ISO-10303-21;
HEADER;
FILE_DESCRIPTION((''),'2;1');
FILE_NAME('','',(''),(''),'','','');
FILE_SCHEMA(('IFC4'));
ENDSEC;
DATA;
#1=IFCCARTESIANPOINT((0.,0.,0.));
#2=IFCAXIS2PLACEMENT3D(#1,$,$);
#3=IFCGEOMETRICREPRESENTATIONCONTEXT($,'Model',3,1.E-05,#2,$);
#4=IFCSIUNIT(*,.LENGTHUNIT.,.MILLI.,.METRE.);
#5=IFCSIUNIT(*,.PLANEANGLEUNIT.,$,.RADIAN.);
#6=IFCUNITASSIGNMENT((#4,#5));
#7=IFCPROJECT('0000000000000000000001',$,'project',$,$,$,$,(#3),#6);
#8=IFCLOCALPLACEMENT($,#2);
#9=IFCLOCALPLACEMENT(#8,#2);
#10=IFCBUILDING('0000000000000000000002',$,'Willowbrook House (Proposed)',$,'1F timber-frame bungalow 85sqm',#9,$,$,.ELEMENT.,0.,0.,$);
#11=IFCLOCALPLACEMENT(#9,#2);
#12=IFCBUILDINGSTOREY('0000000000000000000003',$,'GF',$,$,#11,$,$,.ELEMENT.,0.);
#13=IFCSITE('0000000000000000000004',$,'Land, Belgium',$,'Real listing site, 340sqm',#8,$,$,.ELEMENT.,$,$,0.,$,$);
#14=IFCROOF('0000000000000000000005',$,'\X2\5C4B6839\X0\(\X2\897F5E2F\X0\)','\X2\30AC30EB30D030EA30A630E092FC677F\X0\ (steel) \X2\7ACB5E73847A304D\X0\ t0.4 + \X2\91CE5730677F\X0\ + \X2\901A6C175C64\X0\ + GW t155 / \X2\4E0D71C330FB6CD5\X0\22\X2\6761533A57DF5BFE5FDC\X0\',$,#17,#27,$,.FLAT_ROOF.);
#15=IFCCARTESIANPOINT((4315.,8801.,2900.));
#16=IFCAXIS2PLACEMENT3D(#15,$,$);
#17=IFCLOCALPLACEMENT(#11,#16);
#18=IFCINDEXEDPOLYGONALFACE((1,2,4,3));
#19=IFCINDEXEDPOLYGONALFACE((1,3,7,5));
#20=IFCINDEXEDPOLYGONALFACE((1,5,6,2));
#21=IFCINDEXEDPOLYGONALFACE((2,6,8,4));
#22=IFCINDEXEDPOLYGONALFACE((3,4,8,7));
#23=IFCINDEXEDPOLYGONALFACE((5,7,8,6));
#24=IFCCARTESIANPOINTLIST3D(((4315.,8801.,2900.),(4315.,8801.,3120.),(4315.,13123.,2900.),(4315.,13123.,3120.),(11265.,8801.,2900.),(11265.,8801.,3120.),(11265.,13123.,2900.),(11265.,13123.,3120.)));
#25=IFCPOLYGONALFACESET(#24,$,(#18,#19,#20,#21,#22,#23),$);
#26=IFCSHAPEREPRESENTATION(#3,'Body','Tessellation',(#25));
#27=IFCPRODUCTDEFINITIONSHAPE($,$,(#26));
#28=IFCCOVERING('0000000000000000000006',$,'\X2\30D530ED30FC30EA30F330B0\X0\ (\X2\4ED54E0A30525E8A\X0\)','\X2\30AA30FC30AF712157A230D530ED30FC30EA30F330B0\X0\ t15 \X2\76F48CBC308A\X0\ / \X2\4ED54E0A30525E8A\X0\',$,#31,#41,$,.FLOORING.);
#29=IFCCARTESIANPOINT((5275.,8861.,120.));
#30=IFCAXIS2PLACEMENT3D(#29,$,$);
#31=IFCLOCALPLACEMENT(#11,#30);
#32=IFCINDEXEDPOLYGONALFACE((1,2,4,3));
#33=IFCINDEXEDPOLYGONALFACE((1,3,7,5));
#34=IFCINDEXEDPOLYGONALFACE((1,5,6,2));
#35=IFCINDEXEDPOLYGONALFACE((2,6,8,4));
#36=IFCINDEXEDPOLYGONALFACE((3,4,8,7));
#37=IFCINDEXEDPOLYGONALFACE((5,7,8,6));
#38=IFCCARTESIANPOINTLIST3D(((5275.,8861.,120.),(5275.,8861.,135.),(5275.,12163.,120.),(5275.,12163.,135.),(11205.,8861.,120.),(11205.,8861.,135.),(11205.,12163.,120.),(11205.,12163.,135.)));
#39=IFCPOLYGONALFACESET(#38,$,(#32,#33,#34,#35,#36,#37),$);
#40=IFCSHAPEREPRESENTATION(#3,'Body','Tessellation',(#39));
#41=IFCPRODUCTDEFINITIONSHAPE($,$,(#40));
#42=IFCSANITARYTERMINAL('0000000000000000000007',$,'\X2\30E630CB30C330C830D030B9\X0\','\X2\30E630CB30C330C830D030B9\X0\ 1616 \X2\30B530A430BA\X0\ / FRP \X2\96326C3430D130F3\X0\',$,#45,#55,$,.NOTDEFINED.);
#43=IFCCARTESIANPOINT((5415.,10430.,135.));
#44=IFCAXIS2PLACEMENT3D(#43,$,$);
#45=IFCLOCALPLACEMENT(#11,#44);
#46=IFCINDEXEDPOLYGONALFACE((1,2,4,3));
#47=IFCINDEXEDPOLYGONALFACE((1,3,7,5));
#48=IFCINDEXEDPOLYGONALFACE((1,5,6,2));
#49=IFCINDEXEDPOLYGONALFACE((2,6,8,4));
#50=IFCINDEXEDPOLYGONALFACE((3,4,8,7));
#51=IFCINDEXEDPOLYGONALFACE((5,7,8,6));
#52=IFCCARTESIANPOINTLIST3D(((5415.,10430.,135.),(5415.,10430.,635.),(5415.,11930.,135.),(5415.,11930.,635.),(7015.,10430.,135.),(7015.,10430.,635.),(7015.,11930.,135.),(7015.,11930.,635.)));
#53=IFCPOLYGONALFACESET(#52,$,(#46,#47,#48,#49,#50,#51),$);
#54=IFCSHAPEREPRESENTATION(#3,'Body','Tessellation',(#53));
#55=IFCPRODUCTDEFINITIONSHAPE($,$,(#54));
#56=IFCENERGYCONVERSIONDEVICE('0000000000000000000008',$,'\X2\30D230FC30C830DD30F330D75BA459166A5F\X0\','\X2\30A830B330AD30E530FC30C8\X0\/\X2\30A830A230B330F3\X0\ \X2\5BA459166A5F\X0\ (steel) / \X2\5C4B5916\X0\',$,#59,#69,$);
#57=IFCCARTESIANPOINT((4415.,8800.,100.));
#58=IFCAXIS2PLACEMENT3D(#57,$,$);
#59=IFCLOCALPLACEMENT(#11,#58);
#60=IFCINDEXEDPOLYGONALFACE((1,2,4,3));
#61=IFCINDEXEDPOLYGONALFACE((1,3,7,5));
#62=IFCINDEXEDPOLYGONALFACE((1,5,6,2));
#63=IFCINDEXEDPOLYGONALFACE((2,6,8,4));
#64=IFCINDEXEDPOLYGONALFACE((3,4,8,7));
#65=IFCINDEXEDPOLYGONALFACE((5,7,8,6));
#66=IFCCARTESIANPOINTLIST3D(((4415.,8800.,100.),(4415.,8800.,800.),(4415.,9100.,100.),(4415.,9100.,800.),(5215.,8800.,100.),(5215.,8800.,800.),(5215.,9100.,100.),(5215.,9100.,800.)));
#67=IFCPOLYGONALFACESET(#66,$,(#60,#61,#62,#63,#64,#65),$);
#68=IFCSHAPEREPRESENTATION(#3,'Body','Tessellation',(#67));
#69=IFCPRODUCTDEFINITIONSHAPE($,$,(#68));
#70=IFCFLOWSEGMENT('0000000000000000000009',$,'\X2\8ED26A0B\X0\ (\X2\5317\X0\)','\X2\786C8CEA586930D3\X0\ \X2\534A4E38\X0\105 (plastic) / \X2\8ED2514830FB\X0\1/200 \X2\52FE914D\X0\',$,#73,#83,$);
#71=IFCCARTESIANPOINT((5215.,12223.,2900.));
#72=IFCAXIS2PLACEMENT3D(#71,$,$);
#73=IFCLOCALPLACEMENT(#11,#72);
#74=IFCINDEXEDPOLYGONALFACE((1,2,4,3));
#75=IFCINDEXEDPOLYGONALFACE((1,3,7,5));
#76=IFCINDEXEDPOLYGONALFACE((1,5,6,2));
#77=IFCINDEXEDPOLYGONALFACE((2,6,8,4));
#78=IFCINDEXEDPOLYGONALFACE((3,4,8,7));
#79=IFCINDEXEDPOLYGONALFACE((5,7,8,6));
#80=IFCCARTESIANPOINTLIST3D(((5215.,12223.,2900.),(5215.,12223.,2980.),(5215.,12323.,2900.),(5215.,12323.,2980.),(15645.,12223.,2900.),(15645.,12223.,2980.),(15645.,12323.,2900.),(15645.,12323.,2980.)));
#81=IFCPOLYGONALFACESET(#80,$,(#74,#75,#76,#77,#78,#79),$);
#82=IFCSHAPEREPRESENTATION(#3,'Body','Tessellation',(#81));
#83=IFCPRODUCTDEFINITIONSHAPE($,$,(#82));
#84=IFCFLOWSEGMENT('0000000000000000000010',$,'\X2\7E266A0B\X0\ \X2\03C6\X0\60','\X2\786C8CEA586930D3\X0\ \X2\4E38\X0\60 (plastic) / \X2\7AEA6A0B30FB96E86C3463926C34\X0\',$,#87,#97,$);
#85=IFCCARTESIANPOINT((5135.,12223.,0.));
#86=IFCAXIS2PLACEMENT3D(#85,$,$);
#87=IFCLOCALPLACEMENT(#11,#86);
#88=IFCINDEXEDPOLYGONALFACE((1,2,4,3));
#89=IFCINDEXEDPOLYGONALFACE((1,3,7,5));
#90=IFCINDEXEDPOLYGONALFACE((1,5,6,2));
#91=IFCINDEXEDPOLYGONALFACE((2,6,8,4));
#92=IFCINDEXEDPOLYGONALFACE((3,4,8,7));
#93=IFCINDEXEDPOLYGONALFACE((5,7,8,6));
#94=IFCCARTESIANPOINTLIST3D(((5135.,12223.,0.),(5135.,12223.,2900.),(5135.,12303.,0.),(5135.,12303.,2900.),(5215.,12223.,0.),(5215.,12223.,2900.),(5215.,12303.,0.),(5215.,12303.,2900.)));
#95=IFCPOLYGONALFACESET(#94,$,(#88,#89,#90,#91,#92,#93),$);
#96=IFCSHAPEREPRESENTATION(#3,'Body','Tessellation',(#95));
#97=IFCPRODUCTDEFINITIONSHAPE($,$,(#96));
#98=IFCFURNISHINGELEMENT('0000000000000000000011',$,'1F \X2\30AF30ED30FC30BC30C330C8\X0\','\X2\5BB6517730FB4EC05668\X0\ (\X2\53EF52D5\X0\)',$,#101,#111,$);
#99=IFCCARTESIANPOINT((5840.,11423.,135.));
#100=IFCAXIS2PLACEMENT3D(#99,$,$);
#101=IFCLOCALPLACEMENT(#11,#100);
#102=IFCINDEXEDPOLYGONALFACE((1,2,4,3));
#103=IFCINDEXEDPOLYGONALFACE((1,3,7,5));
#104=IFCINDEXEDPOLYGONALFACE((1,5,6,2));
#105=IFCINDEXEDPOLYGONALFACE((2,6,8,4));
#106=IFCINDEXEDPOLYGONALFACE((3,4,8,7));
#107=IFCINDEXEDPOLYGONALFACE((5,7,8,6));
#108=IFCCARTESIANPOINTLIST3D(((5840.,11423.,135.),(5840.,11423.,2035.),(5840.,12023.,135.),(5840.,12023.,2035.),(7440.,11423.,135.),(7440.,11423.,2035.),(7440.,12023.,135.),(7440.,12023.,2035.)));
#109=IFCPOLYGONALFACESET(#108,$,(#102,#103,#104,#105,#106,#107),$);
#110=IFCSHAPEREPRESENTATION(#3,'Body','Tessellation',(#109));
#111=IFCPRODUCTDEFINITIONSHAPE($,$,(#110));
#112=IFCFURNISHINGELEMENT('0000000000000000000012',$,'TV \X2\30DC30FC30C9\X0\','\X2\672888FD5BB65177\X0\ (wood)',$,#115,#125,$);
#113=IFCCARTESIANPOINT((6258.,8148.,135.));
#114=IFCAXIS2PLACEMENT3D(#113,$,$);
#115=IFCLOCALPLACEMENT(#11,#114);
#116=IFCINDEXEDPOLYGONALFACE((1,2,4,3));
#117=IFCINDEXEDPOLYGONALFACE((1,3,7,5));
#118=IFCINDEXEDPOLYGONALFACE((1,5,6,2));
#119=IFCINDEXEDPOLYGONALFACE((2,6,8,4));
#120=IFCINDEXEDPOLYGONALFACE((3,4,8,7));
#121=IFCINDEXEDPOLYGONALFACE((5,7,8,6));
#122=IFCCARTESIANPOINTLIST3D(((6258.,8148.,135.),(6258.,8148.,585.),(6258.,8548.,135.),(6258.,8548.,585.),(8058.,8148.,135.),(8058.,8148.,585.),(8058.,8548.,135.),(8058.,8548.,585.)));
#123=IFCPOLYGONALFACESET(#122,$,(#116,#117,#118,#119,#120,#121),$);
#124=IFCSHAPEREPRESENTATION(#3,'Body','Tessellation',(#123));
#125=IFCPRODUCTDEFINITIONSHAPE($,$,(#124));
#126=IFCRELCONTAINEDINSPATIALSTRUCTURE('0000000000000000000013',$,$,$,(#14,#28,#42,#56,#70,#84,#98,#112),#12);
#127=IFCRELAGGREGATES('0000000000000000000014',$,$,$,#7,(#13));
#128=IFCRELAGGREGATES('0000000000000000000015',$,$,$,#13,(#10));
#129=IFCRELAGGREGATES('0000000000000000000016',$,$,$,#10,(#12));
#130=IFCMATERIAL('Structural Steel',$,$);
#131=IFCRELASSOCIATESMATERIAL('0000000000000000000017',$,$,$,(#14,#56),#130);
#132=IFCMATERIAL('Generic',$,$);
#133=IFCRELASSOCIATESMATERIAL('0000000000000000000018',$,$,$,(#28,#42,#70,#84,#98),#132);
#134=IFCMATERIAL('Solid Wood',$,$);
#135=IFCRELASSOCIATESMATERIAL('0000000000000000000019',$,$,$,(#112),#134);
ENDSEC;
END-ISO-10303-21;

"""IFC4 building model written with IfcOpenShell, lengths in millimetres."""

from ifc_helpers import new_model, si_unit, frame, frame_2d, origin, place, context, project, spatial, rectangle, extrude, material, element, save


model = new_model("IFC4")

# Units and contexts
model_context = context("Model", 3, precision=1e-05, world=origin())
ifc_project = project(units=[si_unit("LENGTHUNIT", "METRE", prefix="MILLI"), si_unit("PLANEANGLEUNIT", "RADIAN")], contexts=[model_context])

# Site, building, storey
site_placement = place(None, origin())
site = spatial("IfcSite", under=ifc_project, at=site_placement, Name="Land, Belgium", ObjectType="Real listing site, 340sqm", CompositionType="ELEMENT", RefElevation=0.0)
building_placement = place(site_placement, origin())
building = spatial("IfcBuilding", under=site, at=building_placement, Name="Willowbrook House (Proposed)", ObjectType="1F timber-frame bungalow 85sqm", CompositionType="ELEMENT", ElevationOfRefHeight=0.0, ElevationOfTerrain=0.0)
storey_placement = place(building_placement, origin())
storey = spatial("IfcBuildingStorey", under=building, at=storey_placement, Name="GF", CompositionType="ELEMENT", Elevation=0.0)

# Shared definitions
ifc_material_1 = material(Name="Solid Wood")

# Roof
ifc_material_2 = material(Name="Structural Steel")
roof_placement = place(storey_placement, frame((4315.0, 8801.0, 2900.0)))
element("IfcRoof", 1, at=roof_placement, inside=storey, material=ifc_material_2, Name="屋根(西帯)", Description="ガルバリウム鋼板 (steel) 立平葺き t0.4 + 野地板 + 通気層 + GW t155 / 不燃・法22条区域対応", PredefinedType="FLAT_ROOF", context=model_context, shape_type="SweptSolid", body=[
    extrude(rectangle(XDim=6950.0, YDim=4322.0, at=frame_2d((3475.0, 2161.0))), frame((4315.0, 8801.0, 2900.0)), (0.0, 0.0, 1.0), 220.0),
])

# Covering
ifc_material_3 = material(Name="Generic")
covering_placement = place(storey_placement, frame((5275.0, 8861.0, 120.0)))
element("IfcCovering", 2, at=covering_placement, inside=storey, material=ifc_material_3, Name="フローリング (仕上げ床)", Description="オーク無垢フローリング t15 直貼り / 仕上げ床", PredefinedType="FLOORING", context=model_context, shape_type="SweptSolid", body=[
    extrude(rectangle(XDim=5930.0, YDim=3302.0, at=frame_2d((2965.0, 1651.0))), frame((5275.0, 8861.0, 120.0)), (0.0, 0.0, 1.0), 15.0),
])

# Sanitary terminal
sanitary_terminal_placement = place(storey_placement, frame((5415.0, 10430.0, 135.0)))
element("IfcSanitaryTerminal", 3, at=sanitary_terminal_placement, inside=storey, material=ifc_material_3, Name="ユニットバス", Description="ユニットバス 1616 サイズ / FRP 防水パン", PredefinedType="NOTDEFINED", context=model_context, shape_type="SweptSolid", body=[
    extrude(rectangle(XDim=1600.0, YDim=1500.0, at=frame_2d((800.0, 750.0))), frame((5415.0, 10430.0, 135.0)), (0.0, 0.0, 1.0), 500.0),
])

# Energy conversion device
energy_conversion_device_placement = place(storey_placement, frame((4415.0, 8800.0, 100.0)))
element("IfcEnergyConversionDevice", 4, at=energy_conversion_device_placement, inside=storey, material=ifc_material_2, Name="ヒートポンプ室外機", Description="エコキュート/エアコン 室外機 (steel) / 屋外", context=model_context, shape_type="SweptSolid", body=[
    extrude(rectangle(XDim=800.0, YDim=300.0, at=frame_2d((400.0, 150.0))), frame((4415.0, 8800.0, 100.0)), (0.0, 0.0, 1.0), 700.0),
])

# Flow segments
flow_segment_1_placement = place(storey_placement, frame((5215.0, 12223.0, 2900.0)))
element("IfcFlowSegment", 5, at=flow_segment_1_placement, inside=storey, material=ifc_material_3, Name="軒樋 (北)", Description="硬質塩ビ 半丸105 (plastic) / 軒先・1/200 勾配", context=model_context, shape_type="SweptSolid", body=[
    extrude(rectangle(XDim=10430.0, YDim=100.0, at=frame_2d((5215.0, 50.0))), frame((5215.0, 12223.0, 2900.0)), (0.0, 0.0, 1.0), 80.0),
])
flow_segment_2_placement = place(storey_placement, frame((5135.0, 12223.0, 0.0)))
element("IfcFlowSegment", 6, at=flow_segment_2_placement, inside=storey, material=ifc_material_3, Name="縦樋 φ60", Description="硬質塩ビ 丸60 (plastic) / 竪樋・雨水排水", context=model_context, shape_type="SweptSolid", body=[
    extrude(rectangle(XDim=80.0, YDim=80.0, at=frame_2d((40.0, 40.0))), frame((5135.0, 12223.0, 0.0)), (0.0, 0.0, 1.0), 2900.0),
])

# Furnishing elements
furnishing_1_placement = place(storey_placement, frame((5840.0, 11423.0, 135.0)))
element("IfcFurnishingElement", 7, at=furnishing_1_placement, inside=storey, material=ifc_material_3, Name="1F クローゼット", Description="家具・什器 (可動)", context=model_context, shape_type="SweptSolid", body=[
    extrude(rectangle(XDim=1600.0, YDim=600.0, at=frame_2d((800.0, 300.0))), frame((5840.0, 11423.0, 135.0)), (0.0, 0.0, 1.0), 1900.0),
])
furnishing_2_placement = place(storey_placement, frame((6258.0, 8148.0, 135.0)))
element("IfcFurnishingElement", 8, at=furnishing_2_placement, inside=storey, material=ifc_material_1, Name="TV ボード", Description="木製家具 (wood)", context=model_context, shape_type="SweptSolid", body=[
    extrude(rectangle(XDim=1800.0, YDim=400.0, at=frame_2d((900.0, 200.0))), frame((6258.0, 8148.0, 135.0)), (0.0, 0.0, 1.0), 450.0),
])

save(model, "model.ifc")
